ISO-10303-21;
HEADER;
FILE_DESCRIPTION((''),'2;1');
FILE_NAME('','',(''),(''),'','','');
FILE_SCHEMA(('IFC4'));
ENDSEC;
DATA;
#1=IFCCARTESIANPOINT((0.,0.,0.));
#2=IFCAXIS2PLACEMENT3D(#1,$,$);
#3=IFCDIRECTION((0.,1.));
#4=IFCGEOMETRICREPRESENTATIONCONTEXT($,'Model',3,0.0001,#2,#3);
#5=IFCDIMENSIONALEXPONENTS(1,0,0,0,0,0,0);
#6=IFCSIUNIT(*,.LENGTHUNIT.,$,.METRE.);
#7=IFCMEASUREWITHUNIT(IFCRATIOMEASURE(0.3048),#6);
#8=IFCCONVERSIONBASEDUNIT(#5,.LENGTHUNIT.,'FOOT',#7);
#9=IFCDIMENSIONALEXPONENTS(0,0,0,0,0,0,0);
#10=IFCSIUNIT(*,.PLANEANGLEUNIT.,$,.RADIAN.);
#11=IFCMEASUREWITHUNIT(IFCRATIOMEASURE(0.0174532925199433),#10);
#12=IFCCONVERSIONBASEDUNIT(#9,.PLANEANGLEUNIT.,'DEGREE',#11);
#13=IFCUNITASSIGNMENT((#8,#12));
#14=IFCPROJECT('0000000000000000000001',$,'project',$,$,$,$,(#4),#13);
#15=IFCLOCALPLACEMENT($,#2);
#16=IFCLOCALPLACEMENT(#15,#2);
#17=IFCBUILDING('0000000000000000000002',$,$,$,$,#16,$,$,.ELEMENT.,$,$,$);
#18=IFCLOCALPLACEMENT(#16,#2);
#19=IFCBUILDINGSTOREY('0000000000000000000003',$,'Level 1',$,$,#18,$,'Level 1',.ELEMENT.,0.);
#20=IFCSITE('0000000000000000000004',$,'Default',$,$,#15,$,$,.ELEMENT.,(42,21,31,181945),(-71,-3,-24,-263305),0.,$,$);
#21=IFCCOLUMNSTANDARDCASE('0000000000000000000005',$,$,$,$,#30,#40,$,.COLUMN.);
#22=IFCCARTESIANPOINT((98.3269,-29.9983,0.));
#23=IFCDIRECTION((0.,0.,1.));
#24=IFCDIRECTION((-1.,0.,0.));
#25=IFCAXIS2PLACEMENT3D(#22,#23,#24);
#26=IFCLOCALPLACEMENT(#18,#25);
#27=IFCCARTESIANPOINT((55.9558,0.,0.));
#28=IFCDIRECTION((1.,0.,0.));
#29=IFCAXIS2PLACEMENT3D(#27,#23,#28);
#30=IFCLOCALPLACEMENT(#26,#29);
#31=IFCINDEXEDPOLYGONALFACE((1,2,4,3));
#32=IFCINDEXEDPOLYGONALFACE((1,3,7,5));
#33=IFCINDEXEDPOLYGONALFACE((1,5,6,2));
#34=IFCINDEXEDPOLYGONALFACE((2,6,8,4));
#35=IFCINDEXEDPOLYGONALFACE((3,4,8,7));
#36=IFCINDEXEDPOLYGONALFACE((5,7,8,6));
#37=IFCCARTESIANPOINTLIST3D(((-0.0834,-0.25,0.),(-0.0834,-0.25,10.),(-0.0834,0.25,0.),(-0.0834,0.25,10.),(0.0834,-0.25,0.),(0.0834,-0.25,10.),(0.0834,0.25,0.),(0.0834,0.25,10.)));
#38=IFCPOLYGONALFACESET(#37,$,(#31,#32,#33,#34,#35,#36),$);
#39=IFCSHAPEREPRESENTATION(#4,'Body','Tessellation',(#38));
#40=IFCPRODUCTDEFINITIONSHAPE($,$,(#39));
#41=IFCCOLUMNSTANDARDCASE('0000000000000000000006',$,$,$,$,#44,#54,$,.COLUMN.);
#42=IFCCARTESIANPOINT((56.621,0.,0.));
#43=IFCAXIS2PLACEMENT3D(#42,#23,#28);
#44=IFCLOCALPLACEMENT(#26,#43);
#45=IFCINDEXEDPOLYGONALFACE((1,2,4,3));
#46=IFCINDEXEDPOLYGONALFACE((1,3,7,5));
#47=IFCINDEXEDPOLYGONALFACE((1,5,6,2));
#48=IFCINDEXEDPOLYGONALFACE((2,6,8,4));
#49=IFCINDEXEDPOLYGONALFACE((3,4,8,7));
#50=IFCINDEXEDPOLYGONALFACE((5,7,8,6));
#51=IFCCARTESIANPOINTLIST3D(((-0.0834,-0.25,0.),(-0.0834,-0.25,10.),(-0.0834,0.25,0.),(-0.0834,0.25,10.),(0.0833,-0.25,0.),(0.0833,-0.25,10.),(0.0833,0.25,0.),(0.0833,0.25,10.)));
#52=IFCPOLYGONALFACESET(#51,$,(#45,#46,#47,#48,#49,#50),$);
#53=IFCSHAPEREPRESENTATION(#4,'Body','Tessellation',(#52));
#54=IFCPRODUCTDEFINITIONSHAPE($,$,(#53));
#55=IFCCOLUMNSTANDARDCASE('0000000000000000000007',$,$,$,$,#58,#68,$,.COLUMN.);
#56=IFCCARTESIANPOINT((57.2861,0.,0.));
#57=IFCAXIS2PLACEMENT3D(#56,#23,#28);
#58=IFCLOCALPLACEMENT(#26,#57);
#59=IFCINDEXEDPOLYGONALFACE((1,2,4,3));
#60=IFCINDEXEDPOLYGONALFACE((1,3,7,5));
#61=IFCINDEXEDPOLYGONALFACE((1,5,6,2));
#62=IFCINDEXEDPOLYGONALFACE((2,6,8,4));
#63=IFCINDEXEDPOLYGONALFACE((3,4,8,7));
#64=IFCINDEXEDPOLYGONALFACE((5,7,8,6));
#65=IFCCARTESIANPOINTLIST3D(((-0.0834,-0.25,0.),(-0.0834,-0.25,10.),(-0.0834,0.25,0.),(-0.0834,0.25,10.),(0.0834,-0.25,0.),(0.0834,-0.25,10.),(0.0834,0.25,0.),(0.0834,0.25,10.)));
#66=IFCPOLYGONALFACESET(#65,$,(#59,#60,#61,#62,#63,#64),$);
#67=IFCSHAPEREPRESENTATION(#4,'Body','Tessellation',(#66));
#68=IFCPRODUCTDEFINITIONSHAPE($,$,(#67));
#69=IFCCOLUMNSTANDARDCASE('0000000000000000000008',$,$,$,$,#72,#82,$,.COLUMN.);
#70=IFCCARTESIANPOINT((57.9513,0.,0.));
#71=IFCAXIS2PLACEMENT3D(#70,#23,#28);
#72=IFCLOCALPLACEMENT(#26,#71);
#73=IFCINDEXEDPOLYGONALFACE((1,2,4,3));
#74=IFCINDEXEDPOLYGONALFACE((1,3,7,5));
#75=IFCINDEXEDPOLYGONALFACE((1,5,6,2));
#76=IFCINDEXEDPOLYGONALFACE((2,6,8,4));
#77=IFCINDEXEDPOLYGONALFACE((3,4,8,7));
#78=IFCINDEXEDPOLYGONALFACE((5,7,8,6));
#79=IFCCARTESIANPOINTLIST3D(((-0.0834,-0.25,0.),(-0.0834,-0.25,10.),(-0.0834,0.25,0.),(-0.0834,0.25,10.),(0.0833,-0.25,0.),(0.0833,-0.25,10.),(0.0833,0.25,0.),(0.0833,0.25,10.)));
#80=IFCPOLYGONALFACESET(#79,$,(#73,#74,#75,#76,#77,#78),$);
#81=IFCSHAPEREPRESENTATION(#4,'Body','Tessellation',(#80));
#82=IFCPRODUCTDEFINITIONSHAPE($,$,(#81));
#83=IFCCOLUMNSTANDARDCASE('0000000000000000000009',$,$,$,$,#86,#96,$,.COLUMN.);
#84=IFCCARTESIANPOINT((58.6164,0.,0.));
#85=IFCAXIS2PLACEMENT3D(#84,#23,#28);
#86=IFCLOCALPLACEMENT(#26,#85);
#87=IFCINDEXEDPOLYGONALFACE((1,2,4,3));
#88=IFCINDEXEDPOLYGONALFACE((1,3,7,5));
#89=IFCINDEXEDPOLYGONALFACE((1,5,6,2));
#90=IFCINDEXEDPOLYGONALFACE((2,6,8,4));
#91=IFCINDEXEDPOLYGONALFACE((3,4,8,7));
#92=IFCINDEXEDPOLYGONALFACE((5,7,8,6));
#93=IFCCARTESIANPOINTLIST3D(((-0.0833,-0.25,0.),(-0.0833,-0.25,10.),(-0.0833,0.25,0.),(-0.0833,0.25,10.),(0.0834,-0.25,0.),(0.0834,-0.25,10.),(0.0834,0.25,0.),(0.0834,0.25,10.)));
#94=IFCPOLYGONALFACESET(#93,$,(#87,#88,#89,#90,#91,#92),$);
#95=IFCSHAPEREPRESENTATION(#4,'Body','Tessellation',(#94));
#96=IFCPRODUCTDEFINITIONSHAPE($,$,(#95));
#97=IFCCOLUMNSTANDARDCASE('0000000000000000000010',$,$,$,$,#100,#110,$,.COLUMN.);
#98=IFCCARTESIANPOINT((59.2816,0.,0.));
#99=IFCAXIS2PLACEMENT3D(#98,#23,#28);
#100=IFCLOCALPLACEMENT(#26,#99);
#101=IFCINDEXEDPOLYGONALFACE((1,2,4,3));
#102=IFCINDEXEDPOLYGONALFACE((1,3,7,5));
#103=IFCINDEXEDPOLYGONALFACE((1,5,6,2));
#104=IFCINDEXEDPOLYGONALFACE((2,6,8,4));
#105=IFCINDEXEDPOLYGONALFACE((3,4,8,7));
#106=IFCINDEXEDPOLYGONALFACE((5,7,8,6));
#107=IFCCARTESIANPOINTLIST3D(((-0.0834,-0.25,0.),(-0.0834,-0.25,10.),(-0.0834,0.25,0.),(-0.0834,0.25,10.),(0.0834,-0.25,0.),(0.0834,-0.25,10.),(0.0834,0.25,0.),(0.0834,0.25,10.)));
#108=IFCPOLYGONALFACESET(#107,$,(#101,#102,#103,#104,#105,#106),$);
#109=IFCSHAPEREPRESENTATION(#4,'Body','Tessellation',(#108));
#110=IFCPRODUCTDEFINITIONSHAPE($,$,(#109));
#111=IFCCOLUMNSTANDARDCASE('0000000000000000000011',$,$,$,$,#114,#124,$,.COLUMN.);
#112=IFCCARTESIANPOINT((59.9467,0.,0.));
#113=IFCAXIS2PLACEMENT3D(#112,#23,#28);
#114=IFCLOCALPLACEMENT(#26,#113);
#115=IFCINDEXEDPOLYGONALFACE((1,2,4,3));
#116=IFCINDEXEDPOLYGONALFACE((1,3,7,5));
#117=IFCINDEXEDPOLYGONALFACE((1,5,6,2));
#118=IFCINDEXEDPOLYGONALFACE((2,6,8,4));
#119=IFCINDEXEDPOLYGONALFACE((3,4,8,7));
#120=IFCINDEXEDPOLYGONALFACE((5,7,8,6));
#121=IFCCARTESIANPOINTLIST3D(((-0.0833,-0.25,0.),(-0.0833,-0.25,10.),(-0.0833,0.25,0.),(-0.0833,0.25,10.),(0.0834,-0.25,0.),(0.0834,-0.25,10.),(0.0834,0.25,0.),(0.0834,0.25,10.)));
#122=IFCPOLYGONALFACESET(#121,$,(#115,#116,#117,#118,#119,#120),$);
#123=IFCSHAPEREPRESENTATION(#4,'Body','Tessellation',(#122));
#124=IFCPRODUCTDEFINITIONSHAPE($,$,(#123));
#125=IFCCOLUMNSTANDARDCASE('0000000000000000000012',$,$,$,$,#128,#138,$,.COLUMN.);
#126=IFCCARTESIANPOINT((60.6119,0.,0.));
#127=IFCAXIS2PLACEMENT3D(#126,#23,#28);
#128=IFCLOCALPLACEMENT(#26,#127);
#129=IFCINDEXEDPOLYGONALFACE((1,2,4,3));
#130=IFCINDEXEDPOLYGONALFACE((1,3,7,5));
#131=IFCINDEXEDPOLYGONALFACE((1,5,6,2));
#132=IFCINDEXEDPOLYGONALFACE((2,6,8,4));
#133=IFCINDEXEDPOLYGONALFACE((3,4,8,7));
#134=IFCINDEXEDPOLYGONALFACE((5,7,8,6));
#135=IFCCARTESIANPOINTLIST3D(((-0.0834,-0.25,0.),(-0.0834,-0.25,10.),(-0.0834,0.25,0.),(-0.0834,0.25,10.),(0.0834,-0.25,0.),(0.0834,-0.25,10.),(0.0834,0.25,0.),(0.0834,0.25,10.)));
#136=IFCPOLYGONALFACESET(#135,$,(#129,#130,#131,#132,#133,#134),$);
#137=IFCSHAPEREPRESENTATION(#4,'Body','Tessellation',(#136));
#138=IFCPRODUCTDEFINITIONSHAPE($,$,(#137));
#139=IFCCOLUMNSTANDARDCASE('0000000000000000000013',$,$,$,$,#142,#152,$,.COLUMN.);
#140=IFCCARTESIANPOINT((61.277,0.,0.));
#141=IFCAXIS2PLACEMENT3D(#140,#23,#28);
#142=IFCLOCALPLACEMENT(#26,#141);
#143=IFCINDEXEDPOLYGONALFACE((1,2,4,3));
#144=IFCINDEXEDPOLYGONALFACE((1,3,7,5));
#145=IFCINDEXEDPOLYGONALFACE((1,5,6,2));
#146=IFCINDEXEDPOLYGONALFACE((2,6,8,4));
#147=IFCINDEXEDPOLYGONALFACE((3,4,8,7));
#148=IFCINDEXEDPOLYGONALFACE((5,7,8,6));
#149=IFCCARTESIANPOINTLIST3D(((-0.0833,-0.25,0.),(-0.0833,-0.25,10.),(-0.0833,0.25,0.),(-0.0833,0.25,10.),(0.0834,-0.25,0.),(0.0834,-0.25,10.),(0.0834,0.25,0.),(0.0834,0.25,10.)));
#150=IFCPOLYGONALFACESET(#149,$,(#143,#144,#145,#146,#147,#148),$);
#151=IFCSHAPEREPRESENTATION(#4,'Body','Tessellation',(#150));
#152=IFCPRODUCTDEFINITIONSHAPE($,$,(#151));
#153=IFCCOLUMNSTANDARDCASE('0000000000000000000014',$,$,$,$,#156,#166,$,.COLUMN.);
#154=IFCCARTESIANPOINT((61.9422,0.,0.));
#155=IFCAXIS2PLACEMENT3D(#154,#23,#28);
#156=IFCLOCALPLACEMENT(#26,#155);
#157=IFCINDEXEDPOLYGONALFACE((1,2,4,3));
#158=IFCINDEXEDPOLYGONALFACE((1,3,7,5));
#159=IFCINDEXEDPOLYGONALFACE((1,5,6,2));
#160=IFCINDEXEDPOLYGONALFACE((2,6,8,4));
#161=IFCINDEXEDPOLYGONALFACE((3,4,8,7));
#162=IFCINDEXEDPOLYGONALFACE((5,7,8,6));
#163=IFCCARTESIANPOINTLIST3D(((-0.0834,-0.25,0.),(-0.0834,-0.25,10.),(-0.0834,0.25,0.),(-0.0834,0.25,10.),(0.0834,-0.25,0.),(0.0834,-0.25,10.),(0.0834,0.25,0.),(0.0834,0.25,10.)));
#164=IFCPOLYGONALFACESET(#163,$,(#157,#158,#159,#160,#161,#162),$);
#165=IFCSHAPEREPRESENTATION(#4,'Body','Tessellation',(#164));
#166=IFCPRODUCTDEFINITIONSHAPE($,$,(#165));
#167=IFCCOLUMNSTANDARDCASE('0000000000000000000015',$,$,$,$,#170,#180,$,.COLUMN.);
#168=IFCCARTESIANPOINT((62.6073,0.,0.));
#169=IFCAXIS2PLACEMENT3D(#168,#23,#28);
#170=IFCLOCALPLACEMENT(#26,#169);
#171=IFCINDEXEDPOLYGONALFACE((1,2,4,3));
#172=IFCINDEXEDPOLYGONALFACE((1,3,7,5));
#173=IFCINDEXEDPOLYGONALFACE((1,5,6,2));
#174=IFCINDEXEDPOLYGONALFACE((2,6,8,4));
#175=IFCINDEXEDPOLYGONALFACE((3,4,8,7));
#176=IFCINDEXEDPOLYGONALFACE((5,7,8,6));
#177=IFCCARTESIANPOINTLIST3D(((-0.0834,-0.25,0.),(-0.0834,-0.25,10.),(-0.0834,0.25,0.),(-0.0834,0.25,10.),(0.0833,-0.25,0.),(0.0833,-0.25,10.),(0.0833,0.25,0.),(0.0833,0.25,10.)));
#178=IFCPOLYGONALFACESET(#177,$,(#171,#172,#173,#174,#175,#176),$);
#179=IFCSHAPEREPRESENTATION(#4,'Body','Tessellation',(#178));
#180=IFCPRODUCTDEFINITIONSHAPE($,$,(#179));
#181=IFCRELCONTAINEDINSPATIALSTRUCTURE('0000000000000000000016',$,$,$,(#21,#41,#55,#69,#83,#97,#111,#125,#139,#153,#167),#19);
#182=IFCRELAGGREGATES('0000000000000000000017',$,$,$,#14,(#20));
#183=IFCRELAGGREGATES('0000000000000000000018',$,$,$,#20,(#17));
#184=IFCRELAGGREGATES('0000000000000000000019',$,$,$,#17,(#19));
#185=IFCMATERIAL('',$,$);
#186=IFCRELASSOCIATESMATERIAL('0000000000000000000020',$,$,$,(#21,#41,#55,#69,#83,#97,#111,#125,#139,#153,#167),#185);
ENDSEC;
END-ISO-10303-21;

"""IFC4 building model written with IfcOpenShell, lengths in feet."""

from ifc_helpers import new_model, entity, si_unit, converted_unit, direction, frame, origin, place, context, project, spatial, rectangle, extrude, material, element, save


model = new_model("IFC4")

# Units and contexts
model_context = context("Model", 3, precision=0.0001, world=origin(), true_north=direction((0.0, 1.0)))
ifc_project = project(units=[converted_unit("LENGTHUNIT", "FOOT", entity("IfcRatioMeasure", 0.3048), si_unit("LENGTHUNIT", "METRE"), dimensions=[1, 0, 0, 0, 0, 0, 0]), converted_unit("PLANEANGLEUNIT", "DEGREE", entity("IfcRatioMeasure", 0.0174532925199433), si_unit("PLANEANGLEUNIT", "RADIAN"), dimensions=[0, 0, 0, 0, 0, 0, 0])], contexts=[model_context])

# Site, building, storey
site_placement = place(None, origin())
site = spatial("IfcSite", under=ifc_project, at=site_placement, Name="Default", CompositionType="ELEMENT", RefLatitude=(42, 21, 31, 181945), RefLongitude=(-71, -3, -24, -263305), RefElevation=0.0)
building_placement = place(site_placement, origin())
building = spatial("IfcBuilding", under=site, at=building_placement, CompositionType="ELEMENT")
storey_placement = place(building_placement, origin())
storey = spatial("IfcBuildingStorey", under=building, at=storey_placement, Name="Level 1", LongName="Level 1", CompositionType="ELEMENT", Elevation=0.0)

# Columns
ifc_material = material(Name="")
placement = place(storey_placement, frame((98.3269, -29.9983, 0.0), z_axis=(0.0, 0.0, 1.0), x_axis=(-1.0, 0.0, 0.0)))
for number, where, z_axis, x_axis in (
    (1, (55.9558, 0.0, 0.0), (0.0, 0.0, 1.0), (1.0, 0.0, 0.0)),
    (2, (56.621, 0.0, 0.0), (0.0, 0.0, 1.0), (1.0, 0.0, 0.0)),
    (3, (57.2861, 0.0, 0.0), (0.0, 0.0, 1.0), (1.0, 0.0, 0.0)),
    (4, (57.9513, 0.0, 0.0), (0.0, 0.0, 1.0), (1.0, 0.0, 0.0)),
    (5, (58.6164, 0.0, 0.0), (0.0, 0.0, 1.0), (1.0, 0.0, 0.0)),
    (6, (59.2816, 0.0, 0.0), (0.0, 0.0, 1.0), (1.0, 0.0, 0.0)),
    (7, (59.9467, 0.0, 0.0), (0.0, 0.0, 1.0), (1.0, 0.0, 0.0)),
    (8, (60.6119, 0.0, 0.0), (0.0, 0.0, 1.0), (1.0, 0.0, 0.0)),
    (9, (61.277, 0.0, 0.0), (0.0, 0.0, 1.0), (1.0, 0.0, 0.0)),
    (10, (61.9422, 0.0, 0.0), (0.0, 0.0, 1.0), (1.0, 0.0, 0.0)),
    (11, (62.6073, 0.0, 0.0), (0.0, 0.0, 1.0), (1.0, 0.0, 0.0)),
):
    element("IfcColumnStandardCase", number, at=place(placement, frame(where, z_axis=z_axis, x_axis=x_axis)), inside=storey, material=ifc_material, PredefinedType="COLUMN", context=model_context, shape_type="SweptSolid", body=[
        extrude(rectangle(XDim=0.1667, YDim=0.5), origin(), (0.0, 0.0, 1.0), 10.0),
    ])

save(model, "model.ifc")
